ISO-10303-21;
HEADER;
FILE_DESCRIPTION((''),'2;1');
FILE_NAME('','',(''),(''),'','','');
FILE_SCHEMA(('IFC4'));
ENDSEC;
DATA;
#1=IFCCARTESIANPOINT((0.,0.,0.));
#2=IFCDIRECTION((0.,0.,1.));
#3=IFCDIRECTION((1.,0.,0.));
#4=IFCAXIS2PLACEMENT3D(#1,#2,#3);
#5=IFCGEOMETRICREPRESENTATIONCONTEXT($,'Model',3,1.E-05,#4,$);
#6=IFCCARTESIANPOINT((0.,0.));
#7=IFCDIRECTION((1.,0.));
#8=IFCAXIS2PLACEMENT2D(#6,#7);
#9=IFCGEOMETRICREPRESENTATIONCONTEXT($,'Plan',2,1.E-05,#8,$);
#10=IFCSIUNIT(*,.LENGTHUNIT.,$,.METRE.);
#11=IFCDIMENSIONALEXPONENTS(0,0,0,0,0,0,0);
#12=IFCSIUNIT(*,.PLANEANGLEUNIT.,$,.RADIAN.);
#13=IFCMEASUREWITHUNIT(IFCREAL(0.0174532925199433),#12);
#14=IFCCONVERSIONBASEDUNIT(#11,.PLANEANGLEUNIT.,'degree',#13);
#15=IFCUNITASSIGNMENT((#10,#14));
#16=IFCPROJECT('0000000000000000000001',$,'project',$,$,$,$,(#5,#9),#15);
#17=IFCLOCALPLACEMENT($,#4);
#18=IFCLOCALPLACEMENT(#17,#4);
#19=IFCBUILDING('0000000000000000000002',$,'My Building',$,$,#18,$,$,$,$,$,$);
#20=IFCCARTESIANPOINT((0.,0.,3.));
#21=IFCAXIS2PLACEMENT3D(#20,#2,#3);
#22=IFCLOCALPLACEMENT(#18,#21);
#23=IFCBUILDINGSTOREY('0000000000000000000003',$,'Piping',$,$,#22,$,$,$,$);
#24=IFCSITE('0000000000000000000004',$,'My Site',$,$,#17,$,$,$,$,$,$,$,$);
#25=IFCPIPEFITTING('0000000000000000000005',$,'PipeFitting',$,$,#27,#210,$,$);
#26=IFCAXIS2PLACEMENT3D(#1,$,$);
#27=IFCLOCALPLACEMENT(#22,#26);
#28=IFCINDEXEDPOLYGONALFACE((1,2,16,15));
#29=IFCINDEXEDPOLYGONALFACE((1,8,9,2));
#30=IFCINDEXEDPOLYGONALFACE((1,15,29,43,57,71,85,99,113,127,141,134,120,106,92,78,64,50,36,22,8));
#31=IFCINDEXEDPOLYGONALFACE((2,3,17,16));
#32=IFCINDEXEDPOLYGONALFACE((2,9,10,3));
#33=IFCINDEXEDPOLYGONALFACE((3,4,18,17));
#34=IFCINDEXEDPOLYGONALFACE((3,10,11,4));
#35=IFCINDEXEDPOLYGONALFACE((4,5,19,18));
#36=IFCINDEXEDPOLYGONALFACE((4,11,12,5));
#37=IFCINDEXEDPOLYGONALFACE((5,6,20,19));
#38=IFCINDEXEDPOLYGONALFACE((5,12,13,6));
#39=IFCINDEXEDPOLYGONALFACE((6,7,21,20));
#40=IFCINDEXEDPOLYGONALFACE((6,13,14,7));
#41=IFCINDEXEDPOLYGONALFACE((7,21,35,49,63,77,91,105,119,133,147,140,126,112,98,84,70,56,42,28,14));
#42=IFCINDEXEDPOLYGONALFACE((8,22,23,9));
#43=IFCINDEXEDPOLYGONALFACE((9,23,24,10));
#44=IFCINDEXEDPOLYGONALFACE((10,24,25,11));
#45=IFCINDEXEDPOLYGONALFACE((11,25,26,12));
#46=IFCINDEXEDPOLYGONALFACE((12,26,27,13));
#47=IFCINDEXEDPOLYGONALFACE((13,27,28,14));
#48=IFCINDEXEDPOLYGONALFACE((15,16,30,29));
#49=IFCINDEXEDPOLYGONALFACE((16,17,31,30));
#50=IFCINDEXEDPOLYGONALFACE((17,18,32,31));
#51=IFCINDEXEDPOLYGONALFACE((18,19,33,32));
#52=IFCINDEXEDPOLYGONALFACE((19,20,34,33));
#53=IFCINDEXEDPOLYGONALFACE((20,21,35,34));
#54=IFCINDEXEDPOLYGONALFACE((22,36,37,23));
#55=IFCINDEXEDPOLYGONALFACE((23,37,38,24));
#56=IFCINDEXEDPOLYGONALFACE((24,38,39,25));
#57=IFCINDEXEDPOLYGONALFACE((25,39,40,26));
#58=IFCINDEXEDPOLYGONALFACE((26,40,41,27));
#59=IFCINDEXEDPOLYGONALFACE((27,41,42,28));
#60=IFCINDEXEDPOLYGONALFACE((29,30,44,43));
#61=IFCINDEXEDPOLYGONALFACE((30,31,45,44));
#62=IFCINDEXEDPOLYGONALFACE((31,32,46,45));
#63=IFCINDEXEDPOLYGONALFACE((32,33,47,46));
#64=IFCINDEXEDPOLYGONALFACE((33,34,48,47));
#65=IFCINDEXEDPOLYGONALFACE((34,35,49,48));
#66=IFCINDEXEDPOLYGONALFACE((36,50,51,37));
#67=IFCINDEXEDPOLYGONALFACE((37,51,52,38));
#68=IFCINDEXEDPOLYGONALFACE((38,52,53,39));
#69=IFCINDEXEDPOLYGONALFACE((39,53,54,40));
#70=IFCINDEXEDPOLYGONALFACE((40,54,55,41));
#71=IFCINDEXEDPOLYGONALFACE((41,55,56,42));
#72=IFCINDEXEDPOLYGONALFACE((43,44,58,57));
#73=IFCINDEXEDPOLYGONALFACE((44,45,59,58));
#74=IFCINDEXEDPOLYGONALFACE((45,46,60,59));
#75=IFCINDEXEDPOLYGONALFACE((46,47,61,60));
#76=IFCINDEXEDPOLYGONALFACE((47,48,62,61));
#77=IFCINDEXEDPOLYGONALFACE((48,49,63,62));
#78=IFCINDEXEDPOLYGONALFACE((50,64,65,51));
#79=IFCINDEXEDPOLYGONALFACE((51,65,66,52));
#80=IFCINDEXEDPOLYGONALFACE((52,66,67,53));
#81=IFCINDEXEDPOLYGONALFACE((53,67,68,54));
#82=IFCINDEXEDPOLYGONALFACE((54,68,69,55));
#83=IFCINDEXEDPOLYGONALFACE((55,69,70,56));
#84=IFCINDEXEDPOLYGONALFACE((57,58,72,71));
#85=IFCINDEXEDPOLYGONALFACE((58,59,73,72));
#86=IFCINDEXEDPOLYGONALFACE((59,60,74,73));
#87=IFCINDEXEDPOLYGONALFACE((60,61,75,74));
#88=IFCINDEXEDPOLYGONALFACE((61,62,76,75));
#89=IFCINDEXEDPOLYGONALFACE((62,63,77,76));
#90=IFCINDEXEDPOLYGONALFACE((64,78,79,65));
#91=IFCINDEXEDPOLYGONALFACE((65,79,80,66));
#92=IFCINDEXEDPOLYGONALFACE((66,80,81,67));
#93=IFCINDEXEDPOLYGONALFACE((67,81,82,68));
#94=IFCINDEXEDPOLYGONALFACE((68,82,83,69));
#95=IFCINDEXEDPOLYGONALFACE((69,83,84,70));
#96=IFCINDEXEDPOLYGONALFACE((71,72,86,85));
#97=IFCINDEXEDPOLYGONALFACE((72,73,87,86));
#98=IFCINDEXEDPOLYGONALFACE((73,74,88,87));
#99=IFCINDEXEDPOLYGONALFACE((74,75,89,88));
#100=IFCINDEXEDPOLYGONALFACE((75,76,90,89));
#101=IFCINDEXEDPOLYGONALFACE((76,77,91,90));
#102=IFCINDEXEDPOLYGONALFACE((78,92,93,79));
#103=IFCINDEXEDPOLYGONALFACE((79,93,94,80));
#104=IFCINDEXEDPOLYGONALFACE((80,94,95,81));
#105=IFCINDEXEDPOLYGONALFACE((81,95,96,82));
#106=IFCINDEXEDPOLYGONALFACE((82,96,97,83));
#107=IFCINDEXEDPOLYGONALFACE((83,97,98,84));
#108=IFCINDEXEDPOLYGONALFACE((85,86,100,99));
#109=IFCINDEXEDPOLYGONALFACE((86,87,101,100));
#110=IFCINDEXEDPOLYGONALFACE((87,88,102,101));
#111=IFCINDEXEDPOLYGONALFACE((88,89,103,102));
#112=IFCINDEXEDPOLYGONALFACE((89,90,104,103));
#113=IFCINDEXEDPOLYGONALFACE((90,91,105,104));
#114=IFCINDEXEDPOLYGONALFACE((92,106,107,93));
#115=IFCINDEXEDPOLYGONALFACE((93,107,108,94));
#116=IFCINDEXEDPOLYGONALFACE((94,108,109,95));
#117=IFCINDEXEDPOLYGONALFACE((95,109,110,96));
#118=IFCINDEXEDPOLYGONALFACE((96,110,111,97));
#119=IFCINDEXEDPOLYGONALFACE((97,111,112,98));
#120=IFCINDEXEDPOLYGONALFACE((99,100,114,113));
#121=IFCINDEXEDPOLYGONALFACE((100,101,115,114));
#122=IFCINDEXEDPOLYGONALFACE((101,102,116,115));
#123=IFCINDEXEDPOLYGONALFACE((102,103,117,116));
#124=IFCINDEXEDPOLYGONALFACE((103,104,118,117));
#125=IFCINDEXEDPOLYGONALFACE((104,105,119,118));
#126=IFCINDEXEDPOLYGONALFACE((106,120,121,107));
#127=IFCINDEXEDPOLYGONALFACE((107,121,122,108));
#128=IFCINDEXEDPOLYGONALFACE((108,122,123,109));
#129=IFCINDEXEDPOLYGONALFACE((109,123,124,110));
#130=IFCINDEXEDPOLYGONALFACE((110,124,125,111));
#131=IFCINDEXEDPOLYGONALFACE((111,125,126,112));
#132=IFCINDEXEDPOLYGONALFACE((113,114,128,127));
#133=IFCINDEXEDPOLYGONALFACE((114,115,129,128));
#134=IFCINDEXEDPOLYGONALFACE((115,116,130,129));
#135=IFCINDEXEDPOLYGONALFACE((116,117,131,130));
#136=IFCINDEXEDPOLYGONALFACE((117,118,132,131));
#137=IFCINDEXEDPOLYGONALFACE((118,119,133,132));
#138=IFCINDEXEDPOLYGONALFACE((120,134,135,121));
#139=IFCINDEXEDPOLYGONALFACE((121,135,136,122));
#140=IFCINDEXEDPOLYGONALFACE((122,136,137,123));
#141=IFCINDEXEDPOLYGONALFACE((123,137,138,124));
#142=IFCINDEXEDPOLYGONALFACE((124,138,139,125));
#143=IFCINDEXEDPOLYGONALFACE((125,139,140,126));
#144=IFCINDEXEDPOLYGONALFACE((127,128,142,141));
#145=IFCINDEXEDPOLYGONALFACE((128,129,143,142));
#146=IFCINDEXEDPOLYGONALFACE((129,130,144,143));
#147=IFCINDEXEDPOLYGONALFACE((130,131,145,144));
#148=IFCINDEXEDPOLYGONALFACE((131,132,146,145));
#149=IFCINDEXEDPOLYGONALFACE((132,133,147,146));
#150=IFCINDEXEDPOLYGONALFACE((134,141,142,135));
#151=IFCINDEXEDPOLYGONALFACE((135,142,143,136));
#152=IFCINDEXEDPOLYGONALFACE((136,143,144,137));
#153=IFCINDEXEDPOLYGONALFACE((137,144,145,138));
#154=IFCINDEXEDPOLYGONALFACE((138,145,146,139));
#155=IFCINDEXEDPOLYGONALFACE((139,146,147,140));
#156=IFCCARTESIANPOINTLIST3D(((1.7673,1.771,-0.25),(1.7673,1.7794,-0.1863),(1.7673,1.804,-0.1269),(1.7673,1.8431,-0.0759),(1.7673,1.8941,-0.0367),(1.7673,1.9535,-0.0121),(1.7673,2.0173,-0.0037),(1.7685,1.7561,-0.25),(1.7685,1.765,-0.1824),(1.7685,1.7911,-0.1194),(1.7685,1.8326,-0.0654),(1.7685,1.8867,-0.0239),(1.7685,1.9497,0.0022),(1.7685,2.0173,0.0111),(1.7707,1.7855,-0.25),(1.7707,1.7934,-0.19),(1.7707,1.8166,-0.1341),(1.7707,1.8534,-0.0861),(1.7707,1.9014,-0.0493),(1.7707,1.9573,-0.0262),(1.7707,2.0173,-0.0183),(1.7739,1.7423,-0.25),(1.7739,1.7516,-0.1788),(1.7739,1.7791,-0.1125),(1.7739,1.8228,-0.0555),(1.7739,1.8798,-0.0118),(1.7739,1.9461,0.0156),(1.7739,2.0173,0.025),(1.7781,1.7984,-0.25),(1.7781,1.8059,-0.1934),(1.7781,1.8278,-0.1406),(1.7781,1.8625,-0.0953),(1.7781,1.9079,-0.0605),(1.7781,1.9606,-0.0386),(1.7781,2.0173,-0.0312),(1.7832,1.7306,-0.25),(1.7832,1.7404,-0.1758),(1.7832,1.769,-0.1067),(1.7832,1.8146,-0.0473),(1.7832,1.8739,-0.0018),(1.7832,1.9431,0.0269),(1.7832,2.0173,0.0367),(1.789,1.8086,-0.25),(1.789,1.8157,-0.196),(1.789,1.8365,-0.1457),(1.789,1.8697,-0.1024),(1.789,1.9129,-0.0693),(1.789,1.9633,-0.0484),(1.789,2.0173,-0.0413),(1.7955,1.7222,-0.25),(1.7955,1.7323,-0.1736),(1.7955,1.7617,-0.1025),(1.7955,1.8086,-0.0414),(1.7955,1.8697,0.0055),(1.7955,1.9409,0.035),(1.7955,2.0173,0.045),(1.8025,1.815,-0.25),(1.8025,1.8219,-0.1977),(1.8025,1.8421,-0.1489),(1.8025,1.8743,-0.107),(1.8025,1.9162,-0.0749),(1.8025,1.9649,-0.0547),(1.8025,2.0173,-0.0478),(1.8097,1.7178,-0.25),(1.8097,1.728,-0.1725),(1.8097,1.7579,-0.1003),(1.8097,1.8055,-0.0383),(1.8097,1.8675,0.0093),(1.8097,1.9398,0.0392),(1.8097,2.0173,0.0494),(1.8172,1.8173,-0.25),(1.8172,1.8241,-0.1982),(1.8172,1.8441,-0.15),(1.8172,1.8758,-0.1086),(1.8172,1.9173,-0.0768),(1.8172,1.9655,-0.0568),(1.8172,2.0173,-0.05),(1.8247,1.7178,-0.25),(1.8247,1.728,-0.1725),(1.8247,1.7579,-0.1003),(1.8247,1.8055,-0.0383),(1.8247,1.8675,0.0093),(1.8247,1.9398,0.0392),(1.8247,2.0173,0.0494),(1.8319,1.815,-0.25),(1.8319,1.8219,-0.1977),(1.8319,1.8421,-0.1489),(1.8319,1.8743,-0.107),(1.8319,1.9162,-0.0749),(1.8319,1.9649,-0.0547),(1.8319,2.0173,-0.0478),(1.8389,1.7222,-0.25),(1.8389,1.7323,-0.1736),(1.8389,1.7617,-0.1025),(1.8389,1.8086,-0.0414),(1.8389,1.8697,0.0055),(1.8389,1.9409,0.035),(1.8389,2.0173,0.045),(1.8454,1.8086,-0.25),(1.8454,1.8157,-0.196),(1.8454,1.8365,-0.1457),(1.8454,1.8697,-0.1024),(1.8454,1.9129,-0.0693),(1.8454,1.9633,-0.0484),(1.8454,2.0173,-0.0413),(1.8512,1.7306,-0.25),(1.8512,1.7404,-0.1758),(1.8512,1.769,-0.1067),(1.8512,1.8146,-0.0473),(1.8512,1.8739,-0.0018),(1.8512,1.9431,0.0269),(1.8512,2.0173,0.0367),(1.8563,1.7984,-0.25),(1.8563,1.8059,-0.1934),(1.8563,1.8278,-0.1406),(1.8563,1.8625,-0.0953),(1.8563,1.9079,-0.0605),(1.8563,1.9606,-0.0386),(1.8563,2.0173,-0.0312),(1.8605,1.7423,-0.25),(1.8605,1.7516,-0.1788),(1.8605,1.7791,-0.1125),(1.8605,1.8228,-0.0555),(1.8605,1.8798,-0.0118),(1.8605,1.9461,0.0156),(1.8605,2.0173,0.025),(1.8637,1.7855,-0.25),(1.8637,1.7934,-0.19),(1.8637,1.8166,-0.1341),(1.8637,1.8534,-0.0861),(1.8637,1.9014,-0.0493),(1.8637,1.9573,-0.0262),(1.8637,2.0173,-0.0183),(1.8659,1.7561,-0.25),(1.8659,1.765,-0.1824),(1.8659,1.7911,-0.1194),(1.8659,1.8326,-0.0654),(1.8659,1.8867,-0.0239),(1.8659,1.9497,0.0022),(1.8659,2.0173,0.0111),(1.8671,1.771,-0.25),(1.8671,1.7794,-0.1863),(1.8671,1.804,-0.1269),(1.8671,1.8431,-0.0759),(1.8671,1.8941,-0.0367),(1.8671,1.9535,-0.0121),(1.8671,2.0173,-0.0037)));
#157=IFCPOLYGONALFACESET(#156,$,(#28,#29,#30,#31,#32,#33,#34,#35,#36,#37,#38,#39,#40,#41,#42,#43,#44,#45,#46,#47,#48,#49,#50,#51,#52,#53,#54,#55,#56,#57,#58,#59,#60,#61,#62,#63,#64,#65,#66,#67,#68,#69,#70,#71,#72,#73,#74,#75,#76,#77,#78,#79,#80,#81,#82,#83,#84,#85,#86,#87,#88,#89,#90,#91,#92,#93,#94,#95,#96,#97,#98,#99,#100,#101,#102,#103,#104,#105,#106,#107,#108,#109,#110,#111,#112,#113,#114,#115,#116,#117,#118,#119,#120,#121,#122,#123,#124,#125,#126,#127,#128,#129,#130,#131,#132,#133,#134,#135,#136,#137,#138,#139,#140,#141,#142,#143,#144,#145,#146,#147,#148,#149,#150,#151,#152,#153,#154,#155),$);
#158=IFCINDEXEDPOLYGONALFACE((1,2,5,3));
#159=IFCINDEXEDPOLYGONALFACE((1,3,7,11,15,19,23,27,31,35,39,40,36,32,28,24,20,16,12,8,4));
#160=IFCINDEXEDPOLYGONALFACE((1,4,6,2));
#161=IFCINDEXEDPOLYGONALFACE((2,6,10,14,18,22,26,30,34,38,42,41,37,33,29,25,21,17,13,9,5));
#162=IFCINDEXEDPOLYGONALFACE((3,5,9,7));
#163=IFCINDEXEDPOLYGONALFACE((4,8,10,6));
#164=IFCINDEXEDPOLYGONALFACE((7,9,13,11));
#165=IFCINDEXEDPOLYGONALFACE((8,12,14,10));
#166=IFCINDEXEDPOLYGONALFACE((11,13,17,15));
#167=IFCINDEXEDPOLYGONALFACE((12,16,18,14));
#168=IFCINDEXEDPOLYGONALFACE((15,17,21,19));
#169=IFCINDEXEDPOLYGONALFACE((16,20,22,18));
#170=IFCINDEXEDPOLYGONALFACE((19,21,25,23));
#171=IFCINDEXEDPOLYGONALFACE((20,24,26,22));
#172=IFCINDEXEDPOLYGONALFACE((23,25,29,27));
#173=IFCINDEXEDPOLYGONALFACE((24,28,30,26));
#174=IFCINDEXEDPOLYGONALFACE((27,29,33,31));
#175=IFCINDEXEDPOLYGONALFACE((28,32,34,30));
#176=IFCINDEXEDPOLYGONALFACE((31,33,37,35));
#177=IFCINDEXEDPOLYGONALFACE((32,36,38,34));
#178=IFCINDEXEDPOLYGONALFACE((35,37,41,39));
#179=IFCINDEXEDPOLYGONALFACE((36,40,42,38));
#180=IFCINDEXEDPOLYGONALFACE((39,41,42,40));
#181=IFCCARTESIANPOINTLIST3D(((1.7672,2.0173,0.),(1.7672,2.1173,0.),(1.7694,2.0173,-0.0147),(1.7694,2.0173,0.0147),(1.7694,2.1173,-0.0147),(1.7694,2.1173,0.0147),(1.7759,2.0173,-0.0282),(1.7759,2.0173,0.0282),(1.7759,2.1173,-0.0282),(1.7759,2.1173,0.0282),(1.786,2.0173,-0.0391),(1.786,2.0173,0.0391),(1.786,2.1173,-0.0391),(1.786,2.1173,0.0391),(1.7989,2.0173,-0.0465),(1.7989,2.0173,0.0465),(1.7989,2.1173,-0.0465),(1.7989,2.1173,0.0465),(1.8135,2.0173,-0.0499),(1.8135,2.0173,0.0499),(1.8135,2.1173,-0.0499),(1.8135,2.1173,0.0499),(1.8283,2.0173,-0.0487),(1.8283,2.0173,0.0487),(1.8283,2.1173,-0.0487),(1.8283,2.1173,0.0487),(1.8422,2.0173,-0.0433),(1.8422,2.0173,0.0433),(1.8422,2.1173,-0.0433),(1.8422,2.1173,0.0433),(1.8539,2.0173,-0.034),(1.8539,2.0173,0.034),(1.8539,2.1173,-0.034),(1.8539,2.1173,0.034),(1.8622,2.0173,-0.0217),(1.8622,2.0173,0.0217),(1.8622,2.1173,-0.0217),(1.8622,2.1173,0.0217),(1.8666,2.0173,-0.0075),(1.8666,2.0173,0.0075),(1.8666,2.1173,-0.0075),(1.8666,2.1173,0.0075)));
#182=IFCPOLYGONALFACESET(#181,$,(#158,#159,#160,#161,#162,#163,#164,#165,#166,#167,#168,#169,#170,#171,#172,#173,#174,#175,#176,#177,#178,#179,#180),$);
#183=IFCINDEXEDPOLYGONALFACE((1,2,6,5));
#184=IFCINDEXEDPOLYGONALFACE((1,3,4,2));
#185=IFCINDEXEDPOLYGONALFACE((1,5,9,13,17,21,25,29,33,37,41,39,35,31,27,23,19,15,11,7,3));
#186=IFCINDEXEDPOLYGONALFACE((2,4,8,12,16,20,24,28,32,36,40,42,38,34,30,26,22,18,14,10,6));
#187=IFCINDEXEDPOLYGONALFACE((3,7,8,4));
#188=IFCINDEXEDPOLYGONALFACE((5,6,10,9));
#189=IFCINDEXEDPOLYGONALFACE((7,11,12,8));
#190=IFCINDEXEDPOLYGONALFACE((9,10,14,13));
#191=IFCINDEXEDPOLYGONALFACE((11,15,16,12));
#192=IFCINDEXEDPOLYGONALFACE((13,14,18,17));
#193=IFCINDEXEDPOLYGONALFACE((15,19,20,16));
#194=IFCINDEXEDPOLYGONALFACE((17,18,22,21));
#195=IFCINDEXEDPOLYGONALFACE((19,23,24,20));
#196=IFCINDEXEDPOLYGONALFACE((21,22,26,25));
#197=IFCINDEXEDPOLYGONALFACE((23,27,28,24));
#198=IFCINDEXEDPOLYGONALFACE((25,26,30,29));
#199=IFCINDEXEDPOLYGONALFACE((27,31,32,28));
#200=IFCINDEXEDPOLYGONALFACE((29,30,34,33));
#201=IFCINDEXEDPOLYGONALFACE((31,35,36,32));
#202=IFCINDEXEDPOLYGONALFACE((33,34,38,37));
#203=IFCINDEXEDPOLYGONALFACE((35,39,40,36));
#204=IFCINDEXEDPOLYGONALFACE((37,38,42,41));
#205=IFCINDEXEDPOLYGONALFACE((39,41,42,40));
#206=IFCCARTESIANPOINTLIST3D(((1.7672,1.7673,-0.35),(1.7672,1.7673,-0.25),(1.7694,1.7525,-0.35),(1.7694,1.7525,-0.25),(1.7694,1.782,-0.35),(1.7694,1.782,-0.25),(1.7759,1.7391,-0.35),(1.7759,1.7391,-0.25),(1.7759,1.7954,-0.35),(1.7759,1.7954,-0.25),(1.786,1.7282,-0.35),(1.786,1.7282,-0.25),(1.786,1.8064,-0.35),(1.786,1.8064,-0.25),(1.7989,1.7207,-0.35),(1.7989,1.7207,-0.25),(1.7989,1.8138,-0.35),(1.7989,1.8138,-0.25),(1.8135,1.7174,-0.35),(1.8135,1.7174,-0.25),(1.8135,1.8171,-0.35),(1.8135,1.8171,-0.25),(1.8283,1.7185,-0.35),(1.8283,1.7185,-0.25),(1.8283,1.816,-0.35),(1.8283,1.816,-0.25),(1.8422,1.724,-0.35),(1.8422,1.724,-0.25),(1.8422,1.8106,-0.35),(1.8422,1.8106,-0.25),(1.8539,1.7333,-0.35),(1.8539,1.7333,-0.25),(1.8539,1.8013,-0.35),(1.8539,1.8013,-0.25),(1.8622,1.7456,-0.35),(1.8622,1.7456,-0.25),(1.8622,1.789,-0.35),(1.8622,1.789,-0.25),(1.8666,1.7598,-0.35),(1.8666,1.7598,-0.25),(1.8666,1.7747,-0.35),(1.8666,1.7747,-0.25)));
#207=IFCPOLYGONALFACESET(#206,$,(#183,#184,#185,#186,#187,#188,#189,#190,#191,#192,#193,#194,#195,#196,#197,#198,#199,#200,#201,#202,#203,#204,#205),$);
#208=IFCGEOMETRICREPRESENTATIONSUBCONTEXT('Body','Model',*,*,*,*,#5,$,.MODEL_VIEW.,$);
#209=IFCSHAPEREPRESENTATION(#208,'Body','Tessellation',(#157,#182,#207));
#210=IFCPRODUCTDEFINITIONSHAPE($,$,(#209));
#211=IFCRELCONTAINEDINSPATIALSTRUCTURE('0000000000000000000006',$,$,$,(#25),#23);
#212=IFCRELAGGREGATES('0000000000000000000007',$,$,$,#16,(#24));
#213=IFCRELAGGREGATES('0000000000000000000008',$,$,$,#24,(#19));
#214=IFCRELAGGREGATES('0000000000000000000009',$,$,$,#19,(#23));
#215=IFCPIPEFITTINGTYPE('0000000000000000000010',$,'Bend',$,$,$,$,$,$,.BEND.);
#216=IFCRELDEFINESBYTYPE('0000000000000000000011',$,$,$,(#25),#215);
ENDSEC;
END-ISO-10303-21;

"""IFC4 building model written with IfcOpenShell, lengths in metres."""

from ifc_helpers import new_model, entity, si_unit, converted_unit, frame, origin_with_axes, origin_2d_with_axis, place, context, subcontext, project, spatial, circle, extrude, source, transform, mapped, type_object, type_shapes, element, save


model = new_model("IFC4")

# Units and contexts
model_context = context("Model", 3, precision=1e-05, world=origin_with_axes())
plan_context = context("Plan", 2, precision=1e-05, world=origin_2d_with_axis())
body_context = subcontext(model_context, "Body", "Model", "MODEL_VIEW")
ifc_project = project(units=[si_unit("LENGTHUNIT", "METRE"), converted_unit("PLANEANGLEUNIT", "degree", entity("IfcReal", 0.0174532925199433), si_unit("PLANEANGLEUNIT", "RADIAN"), dimensions=[0, 0, 0, 0, 0, 0, 0])], contexts=[model_context, plan_context])

# Site, building, storey
site_placement = place(None, origin_with_axes())
site = spatial("IfcSite", under=ifc_project, at=site_placement, Name="My Site")
building_placement = place(site_placement, origin_with_axes())
building = spatial("IfcBuilding", under=site, at=building_placement, Name="My Building")
storey_placement = place(building_placement, frame((0.0, 0.0, 3.0), z_axis=(0.0, 0.0, 1.0), x_axis=(1.0, 0.0, 0.0)))
storey = spatial("IfcBuildingStorey", under=building, at=storey_placement, Name="Piping")

# Pipe fitting
pipe_fitting_type = type_object("IfcPipeFittingType", Name="Bend", PredefinedType="BEND")
shared_shape = source(origin_with_axes(), body_context, "Body", "SolidModel", [
    entity("IfcSweptDiskSolid", entity("IfcIndexedPolyCurve", entity("IfcCartesianPointList3D", [[0.0, 0.0, -0.1], [0.0, -0.0732, -0.2768], [0.0, -0.25, -0.35]]), [entity("IfcArcIndex", [1, 2, 3])]), 0.05),
    extrude(circle(Radius=0.05), origin_with_axes(), (0.0, 0.0, -1.0), 0.1),
    extrude(circle(Radius=0.05), frame((0.0, -0.25, -0.35), z_axis=(0.0, -1.0, 0.0), x_axis=(1.0, 0.0, 0.0)), (0.0, 0.0, 1.0), 0.1),
])
type_shapes(pipe_fitting_type, [shared_shape])
for number, where, z_axis, x_axis, name in (
    (1, (1.8172, 2.1173, 0.0), (0.0, 1.0, 0.0), (-1.0, 0.0, 0.0), "PipeFitting"),
):
    element("IfcPipeFitting", number, at=place(storey_placement, frame(where, z_axis=z_axis, x_axis=x_axis)), inside=storey, type_object=pipe_fitting_type, Name=name, context=body_context, shape_type="MappedRepresentation", body=[
        mapped(shared_shape, transform((0.0, 0.0, 0.0), x_axis=(1.0, 0.0, 0.0), y_axis=(0.0, 1.0, 0.0), z_axis=(0.0, 0.0, 1.0), scale=1.0)),
    ])

save(model, "model.ifc")
